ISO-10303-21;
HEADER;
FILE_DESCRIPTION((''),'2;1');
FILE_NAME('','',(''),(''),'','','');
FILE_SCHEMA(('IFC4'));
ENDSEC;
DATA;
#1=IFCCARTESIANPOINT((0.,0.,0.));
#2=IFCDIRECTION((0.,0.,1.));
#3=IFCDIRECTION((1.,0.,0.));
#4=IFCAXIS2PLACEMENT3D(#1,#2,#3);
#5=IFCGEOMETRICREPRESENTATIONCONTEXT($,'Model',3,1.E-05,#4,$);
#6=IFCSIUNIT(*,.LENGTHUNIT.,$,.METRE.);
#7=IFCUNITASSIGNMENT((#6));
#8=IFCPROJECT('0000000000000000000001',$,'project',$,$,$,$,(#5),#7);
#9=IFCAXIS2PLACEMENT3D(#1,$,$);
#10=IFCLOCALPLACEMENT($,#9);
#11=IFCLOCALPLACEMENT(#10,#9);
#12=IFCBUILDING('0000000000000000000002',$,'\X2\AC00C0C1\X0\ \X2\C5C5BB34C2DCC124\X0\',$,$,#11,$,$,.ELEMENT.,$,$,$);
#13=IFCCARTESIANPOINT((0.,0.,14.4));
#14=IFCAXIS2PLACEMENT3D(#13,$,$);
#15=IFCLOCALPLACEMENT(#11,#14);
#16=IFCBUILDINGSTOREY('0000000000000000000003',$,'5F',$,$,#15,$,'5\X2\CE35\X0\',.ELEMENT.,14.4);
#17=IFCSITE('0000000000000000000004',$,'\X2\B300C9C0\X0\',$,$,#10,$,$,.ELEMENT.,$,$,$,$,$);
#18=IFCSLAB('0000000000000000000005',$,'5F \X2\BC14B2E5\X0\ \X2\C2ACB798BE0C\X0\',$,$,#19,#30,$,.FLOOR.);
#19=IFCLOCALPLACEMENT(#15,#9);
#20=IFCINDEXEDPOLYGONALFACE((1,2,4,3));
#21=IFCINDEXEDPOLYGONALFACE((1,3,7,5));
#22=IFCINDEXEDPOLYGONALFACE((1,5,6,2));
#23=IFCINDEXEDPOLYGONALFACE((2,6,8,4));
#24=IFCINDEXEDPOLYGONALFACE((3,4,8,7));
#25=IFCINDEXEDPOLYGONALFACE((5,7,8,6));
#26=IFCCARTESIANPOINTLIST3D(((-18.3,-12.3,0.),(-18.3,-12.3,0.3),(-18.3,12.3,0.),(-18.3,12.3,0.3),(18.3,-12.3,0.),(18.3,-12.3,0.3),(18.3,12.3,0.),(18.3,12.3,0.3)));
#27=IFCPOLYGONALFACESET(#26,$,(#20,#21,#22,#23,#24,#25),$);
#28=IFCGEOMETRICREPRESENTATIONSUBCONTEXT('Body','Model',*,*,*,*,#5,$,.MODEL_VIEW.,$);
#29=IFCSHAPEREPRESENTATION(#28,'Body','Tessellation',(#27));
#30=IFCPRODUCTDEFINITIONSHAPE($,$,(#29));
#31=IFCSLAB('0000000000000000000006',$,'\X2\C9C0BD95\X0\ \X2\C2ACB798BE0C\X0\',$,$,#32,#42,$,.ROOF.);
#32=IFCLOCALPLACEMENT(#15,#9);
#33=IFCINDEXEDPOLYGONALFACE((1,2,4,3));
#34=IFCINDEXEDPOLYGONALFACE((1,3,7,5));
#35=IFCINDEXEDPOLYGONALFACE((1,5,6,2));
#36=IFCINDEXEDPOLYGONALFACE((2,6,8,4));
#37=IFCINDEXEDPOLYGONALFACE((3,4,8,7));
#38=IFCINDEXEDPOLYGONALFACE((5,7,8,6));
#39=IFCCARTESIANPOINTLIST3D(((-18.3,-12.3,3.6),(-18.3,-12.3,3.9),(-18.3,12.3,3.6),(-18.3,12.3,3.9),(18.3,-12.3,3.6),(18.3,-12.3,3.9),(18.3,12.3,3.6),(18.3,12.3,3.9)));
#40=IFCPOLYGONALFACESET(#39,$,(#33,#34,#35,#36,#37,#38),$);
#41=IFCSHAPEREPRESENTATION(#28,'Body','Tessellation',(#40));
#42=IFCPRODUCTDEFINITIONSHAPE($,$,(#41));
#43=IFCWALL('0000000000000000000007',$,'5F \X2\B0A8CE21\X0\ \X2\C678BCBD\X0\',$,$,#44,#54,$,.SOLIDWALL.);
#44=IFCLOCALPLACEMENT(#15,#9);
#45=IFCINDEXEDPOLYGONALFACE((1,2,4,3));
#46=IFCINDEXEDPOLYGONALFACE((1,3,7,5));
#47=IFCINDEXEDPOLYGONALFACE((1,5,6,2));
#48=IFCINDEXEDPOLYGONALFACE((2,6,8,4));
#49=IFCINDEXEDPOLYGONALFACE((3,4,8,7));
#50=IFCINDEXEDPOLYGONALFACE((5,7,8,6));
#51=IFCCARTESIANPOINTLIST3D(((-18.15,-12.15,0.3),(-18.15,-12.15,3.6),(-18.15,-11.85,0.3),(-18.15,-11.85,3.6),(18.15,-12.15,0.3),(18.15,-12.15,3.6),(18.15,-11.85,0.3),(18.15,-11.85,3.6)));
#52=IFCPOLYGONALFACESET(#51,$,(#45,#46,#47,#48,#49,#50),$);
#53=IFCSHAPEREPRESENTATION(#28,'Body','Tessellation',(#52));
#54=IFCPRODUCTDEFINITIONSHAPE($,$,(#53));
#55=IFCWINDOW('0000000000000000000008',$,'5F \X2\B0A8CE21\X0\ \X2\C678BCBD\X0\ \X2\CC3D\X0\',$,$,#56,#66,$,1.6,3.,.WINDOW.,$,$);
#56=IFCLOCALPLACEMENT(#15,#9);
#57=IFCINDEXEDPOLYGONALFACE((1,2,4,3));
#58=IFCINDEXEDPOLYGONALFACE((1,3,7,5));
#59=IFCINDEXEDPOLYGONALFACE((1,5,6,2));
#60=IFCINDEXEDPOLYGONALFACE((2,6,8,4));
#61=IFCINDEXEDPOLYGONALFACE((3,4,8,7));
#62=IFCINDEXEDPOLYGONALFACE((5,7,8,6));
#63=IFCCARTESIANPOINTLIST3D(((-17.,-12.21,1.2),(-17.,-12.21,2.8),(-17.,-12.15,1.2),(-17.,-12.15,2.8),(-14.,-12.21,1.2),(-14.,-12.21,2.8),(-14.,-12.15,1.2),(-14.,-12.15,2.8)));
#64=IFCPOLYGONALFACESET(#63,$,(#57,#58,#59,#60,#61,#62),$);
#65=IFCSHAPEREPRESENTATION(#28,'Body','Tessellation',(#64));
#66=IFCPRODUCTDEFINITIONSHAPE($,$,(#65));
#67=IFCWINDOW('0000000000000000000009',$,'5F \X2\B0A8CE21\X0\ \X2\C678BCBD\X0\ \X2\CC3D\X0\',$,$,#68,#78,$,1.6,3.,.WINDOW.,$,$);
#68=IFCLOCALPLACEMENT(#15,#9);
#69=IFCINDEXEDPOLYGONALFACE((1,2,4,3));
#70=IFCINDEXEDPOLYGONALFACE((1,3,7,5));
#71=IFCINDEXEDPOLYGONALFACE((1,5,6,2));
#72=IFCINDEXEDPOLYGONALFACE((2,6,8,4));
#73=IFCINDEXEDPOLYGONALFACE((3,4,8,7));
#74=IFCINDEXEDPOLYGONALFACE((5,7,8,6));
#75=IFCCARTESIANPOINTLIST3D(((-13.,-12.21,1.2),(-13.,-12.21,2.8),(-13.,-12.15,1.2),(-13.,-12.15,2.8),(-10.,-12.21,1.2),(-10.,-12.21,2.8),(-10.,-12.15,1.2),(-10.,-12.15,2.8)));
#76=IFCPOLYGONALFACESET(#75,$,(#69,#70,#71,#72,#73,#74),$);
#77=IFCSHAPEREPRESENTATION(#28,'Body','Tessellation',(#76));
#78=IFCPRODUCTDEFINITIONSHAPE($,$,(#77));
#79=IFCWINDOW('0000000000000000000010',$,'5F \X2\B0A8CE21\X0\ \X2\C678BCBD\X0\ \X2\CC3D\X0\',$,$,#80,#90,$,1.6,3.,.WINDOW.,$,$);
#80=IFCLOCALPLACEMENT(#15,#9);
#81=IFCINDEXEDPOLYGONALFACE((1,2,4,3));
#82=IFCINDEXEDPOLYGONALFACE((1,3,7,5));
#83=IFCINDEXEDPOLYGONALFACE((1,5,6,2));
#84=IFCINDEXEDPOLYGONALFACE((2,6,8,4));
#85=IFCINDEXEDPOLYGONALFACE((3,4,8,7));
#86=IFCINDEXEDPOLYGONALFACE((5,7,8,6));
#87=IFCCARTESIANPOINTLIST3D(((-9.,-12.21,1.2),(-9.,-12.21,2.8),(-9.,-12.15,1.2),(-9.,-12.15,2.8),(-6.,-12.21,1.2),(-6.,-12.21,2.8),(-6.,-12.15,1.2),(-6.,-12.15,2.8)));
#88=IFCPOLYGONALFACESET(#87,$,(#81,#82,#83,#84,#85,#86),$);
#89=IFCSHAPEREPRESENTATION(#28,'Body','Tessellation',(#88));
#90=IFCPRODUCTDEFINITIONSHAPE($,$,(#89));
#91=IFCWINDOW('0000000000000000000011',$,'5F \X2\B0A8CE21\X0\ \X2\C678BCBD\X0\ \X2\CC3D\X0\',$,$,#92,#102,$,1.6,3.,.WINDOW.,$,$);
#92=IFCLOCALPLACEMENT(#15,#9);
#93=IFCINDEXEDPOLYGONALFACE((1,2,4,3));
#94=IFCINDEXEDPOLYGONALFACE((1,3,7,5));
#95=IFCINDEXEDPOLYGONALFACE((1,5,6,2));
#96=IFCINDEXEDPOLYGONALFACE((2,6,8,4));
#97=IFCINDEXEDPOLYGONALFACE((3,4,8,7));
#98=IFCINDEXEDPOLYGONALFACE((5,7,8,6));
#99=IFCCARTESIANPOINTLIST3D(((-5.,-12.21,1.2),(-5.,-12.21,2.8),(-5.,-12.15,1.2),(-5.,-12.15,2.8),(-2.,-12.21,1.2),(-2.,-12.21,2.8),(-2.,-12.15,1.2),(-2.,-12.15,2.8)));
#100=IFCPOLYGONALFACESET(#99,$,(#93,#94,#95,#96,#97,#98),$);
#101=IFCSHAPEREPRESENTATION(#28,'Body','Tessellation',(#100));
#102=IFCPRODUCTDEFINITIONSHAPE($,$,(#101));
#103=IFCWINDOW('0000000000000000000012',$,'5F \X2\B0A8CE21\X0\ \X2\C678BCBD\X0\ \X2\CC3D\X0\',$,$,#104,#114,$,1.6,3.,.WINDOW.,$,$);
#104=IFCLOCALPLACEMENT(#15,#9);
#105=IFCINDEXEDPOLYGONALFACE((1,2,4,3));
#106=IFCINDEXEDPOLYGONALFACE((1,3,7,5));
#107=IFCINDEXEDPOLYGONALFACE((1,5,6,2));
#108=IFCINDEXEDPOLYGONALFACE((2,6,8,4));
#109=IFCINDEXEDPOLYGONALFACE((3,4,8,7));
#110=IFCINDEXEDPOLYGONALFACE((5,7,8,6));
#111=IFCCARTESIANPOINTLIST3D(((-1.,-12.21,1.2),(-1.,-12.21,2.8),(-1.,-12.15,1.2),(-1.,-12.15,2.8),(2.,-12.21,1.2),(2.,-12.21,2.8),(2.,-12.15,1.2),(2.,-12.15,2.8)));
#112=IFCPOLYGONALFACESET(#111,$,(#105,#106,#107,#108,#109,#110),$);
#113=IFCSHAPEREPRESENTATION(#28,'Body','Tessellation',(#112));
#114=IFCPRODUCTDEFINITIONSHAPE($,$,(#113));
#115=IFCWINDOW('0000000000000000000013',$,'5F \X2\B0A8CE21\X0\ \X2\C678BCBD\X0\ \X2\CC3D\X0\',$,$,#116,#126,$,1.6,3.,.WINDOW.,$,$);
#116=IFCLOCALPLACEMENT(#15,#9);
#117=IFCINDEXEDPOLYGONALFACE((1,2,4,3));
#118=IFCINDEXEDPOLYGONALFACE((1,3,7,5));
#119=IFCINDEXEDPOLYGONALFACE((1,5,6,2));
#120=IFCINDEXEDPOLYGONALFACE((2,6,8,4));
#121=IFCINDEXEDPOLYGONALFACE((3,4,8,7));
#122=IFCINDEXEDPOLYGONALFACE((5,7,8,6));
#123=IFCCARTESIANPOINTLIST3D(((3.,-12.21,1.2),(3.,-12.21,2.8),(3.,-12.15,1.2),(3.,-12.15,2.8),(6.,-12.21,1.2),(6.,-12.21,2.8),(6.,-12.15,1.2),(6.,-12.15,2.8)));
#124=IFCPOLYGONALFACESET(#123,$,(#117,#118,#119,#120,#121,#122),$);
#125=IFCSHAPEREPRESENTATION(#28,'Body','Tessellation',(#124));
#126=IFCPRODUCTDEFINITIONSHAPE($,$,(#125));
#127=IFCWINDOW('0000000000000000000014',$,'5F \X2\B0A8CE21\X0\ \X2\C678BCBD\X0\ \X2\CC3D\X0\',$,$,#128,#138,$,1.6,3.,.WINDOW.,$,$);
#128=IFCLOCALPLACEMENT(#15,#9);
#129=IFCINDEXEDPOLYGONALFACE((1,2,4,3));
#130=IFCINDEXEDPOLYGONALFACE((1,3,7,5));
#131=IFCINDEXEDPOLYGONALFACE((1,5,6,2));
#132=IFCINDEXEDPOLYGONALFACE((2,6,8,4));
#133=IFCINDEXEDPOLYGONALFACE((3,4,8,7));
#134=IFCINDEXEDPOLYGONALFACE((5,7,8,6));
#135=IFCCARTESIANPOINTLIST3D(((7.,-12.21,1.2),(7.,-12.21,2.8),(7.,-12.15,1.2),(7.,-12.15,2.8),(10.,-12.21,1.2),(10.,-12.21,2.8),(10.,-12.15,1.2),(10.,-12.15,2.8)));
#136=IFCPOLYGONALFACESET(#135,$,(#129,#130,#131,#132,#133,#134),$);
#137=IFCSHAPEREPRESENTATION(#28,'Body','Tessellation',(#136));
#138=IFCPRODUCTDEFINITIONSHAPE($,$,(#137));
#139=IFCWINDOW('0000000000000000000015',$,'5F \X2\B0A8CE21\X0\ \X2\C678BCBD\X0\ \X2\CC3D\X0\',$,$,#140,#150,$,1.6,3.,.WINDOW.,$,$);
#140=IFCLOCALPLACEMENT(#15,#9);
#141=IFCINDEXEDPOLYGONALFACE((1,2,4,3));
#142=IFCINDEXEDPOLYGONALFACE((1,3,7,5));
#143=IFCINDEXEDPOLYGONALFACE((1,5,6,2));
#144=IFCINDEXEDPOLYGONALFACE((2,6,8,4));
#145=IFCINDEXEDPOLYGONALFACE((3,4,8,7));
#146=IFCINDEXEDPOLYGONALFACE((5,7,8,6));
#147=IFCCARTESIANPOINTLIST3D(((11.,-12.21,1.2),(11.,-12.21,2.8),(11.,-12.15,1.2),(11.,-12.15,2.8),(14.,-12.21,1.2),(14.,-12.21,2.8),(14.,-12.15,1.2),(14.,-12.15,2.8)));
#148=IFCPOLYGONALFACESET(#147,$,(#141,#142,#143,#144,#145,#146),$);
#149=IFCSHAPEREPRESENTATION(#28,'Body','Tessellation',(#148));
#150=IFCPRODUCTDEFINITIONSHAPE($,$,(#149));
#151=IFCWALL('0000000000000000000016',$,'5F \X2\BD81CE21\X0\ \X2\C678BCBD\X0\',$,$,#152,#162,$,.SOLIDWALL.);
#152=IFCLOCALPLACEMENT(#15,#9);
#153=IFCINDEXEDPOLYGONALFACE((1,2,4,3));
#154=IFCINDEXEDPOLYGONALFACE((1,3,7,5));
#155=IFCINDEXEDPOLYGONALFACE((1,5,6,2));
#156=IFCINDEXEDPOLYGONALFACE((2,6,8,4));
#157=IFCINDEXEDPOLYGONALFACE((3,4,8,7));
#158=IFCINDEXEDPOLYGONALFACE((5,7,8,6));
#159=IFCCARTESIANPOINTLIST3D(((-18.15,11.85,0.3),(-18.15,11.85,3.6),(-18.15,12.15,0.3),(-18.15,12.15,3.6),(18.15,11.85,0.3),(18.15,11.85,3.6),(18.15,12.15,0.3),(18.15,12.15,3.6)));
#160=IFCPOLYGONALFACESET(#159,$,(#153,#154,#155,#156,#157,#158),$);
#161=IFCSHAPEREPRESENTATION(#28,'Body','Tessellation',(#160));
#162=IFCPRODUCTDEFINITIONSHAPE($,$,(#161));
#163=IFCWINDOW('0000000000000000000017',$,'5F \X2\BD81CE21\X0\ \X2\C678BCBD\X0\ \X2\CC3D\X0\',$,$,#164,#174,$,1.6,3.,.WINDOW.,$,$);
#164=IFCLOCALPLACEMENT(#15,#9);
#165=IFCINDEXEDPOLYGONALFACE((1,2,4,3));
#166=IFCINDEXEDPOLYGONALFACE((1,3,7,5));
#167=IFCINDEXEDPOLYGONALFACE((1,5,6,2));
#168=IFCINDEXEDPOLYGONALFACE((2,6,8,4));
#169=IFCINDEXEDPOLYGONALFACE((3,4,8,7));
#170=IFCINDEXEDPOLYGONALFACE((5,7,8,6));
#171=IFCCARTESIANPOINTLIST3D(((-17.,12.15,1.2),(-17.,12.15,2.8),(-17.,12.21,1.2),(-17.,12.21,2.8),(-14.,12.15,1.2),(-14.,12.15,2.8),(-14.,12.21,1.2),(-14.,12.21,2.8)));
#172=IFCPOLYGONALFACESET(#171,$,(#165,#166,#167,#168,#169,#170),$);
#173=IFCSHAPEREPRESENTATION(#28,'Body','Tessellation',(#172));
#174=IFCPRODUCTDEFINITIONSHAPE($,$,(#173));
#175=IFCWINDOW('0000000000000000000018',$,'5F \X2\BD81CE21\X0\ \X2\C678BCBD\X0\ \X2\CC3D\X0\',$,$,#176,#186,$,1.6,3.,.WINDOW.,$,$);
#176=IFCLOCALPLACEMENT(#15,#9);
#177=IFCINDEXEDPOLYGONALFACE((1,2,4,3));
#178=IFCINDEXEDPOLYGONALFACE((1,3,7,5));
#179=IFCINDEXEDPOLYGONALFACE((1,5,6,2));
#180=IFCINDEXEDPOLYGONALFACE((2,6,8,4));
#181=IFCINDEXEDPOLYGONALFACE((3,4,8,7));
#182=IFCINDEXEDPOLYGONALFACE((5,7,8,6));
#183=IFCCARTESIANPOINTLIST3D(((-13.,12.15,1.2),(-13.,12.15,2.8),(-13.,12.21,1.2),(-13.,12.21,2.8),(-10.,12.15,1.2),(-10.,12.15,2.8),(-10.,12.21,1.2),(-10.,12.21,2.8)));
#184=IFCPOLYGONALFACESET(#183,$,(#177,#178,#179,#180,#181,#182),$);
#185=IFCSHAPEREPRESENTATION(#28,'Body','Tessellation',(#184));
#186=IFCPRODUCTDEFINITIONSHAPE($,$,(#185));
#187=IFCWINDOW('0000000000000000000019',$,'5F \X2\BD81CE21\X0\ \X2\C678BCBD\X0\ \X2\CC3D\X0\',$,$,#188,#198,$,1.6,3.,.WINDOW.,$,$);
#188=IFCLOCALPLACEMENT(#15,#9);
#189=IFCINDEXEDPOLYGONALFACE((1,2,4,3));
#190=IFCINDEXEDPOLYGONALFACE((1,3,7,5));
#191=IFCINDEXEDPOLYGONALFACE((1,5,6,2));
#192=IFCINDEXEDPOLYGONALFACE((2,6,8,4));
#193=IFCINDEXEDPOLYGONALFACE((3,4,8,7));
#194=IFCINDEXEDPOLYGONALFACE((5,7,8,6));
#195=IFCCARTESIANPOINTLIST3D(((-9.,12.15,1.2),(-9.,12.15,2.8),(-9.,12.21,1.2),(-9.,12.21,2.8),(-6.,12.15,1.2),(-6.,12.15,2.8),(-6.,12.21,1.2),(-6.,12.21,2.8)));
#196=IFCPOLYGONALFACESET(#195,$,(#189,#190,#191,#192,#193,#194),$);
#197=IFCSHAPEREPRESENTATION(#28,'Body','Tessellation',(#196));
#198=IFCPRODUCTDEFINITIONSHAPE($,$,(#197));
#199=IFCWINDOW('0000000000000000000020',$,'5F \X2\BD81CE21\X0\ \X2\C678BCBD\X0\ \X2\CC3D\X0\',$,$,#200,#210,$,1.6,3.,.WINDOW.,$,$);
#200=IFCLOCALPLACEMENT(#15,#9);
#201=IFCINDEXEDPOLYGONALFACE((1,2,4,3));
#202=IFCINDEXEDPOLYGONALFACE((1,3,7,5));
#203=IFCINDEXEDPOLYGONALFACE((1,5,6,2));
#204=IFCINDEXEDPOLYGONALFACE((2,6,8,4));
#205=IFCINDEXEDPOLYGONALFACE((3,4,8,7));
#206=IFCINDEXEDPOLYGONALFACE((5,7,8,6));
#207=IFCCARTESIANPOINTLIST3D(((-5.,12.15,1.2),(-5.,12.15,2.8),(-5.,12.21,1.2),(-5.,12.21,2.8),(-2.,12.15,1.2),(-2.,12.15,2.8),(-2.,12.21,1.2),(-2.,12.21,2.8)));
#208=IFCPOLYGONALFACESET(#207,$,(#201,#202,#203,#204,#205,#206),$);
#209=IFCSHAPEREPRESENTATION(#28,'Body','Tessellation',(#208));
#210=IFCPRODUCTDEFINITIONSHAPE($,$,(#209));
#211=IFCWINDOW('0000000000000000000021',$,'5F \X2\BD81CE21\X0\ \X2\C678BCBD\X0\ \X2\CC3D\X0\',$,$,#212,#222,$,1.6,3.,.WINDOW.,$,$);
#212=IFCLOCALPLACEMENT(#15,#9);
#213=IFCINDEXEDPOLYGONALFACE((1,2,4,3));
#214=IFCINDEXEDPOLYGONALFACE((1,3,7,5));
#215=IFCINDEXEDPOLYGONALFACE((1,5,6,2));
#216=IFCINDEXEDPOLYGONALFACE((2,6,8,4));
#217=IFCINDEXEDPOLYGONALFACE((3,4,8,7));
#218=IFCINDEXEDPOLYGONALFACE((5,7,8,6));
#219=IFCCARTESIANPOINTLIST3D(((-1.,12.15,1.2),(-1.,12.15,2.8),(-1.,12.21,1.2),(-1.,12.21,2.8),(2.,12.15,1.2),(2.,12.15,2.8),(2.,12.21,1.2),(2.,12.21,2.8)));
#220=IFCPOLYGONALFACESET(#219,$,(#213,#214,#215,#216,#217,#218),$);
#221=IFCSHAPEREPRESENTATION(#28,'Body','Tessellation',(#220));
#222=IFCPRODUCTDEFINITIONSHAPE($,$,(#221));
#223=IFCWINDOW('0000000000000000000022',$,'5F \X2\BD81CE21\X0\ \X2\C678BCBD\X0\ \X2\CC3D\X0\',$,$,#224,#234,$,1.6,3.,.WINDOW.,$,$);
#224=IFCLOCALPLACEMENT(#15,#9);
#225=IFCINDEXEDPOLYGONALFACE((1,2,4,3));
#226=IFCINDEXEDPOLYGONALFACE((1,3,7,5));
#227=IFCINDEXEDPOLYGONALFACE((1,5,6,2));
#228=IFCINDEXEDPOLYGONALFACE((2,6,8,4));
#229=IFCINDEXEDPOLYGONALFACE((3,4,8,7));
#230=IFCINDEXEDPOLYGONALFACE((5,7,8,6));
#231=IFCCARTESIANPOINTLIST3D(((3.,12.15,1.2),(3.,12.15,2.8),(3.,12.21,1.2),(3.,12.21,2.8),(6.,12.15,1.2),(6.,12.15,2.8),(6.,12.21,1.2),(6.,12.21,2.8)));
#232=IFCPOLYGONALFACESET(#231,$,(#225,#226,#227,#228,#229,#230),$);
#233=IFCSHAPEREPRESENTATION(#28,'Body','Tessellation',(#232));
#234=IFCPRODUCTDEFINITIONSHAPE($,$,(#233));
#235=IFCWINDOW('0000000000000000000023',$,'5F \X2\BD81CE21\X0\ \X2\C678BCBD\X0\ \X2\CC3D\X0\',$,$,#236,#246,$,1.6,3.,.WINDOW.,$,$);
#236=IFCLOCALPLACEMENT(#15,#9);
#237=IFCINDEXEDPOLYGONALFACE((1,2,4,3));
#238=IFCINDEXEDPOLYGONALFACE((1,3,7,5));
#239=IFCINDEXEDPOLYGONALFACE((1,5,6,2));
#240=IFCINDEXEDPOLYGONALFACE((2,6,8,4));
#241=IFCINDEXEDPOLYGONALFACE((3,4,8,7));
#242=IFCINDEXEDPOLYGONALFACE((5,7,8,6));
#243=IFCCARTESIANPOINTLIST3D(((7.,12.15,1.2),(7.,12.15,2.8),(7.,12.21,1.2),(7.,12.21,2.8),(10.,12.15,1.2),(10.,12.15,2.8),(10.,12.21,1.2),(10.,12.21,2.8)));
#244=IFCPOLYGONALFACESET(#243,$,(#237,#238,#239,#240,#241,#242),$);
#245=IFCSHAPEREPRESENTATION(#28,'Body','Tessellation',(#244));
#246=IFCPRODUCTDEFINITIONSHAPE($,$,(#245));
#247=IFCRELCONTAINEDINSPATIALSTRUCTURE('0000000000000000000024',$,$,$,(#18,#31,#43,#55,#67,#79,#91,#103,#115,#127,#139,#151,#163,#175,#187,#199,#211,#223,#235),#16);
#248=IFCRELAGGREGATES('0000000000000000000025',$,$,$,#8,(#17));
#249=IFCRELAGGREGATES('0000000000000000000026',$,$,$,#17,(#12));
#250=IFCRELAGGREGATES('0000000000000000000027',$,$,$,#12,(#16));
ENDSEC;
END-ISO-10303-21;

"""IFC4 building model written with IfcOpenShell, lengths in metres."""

from ifc_helpers import new_model, si_unit, frame, origin, origin_with_axes, origin_2d, place, context, subcontext, project, spatial, rectangle, extrude, element, save


model = new_model("IFC4")

# Units and contexts
model_context = context("Model", 3, precision=1e-05, world=origin_with_axes())
body_context = subcontext(model_context, "Body", "Model", "MODEL_VIEW")
ifc_project = project(units=[si_unit("LENGTHUNIT", "METRE")], contexts=[model_context])

# Site, building, storey
site_placement = place(None, origin())
site = spatial("IfcSite", under=ifc_project, at=site_placement, Name="대지", CompositionType="ELEMENT")
building_placement = place(site_placement, origin())
building = spatial("IfcBuilding", under=site, at=building_placement, Name="가상 업무시설", CompositionType="ELEMENT")
storey_placement = place(building_placement, frame((0.0, 0.0, 14.4)))
storey = spatial("IfcBuildingStorey", under=building, at=storey_placement, Name="5F", LongName="5층", CompositionType="ELEMENT", Elevation=14.4)

# Slabs
slab_1_placement = place(storey_placement, origin())
element("IfcSlab", 1, at=slab_1_placement, inside=storey, Name="5F 바닥 슬래브", PredefinedType="FLOOR", context=body_context, shape_type="SweptSolid", body=[
    extrude(rectangle(XDim=36.6, YDim=24.6, at=origin_2d()), origin_with_axes(), (0.0, 0.0, 1.0), 0.3),
])
slab_2_placement = place(storey_placement, frame((0.0, 0.0, 3.6)))
element("IfcSlab", 2, at=slab_2_placement, inside=storey, Name="지붕 슬래브", PredefinedType="ROOF", context=body_context, shape_type="SweptSolid", body=[
    extrude(rectangle(XDim=36.6, YDim=24.6, at=origin_2d()), origin_with_axes(), (0.0, 0.0, 1.0), 0.3),
])

# Wall
wall_1_placement = place(storey_placement, frame((0.0, -12.0, 0.3)))
element("IfcWall", 3, at=wall_1_placement, inside=storey, Name="5F 남측 외벽", PredefinedType="SOLIDWALL", context=body_context, shape_type="SweptSolid", body=[
    extrude(rectangle(XDim=36.3, YDim=0.3, at=origin_2d()), origin_with_axes(), (0.0, 0.0, 1.0), 3.3),
])

# Windows
for number, where, name in (
    (4, (-15.5, -12.18, 1.2), "5F 남측 외벽 창"),
    (5, (-11.5, -12.18, 1.2), "5F 남측 외벽 창"),
    (6, (-7.5, -12.18, 1.2), "5F 남측 외벽 창"),
    (7, (-3.5, -12.18, 1.2), "5F 남측 외벽 창"),
    (8, (0.5, -12.18, 1.2), "5F 남측 외벽 창"),
    (9, (4.5, -12.18, 1.2), "5F 남측 외벽 창"),
    (10, (8.5, -12.18, 1.2), "5F 남측 외벽 창"),
    (11, (12.5, -12.18, 1.2), "5F 남측 외벽 창"),
):
    element("IfcWindow", number, at=place(storey_placement, frame(where)), inside=storey, Name=name, OverallHeight=1.6, OverallWidth=3.0, PredefinedType="WINDOW", context=body_context, shape_type="SweptSolid", body=[
        extrude(rectangle(XDim=3.0, YDim=0.06, at=origin_2d()), origin_with_axes(), (0.0, 0.0, 1.0), 1.6),
    ])

# Wall
wall_2_placement = place(storey_placement, frame((0.0, 12.0, 0.3)))
element("IfcWall", 12, at=wall_2_placement, inside=storey, Name="5F 북측 외벽", PredefinedType="SOLIDWALL", context=body_context, shape_type="SweptSolid", body=[
    extrude(rectangle(XDim=36.3, YDim=0.3, at=origin_2d()), origin_with_axes(), (0.0, 0.0, 1.0), 3.3),
])

# Windows
for number, where, name in (
    (13, (-15.5, 12.18, 1.2), "5F 북측 외벽 창"),
    (14, (-11.5, 12.18, 1.2), "5F 북측 외벽 창"),
    (15, (-7.5, 12.18, 1.2), "5F 북측 외벽 창"),
    (16, (-3.5, 12.18, 1.2), "5F 북측 외벽 창"),
    (17, (0.5, 12.18, 1.2), "5F 북측 외벽 창"),
    (18, (4.5, 12.18, 1.2), "5F 북측 외벽 창"),
    (19, (8.5, 12.18, 1.2), "5F 북측 외벽 창"),
):
    element("IfcWindow", number, at=place(storey_placement, frame(where)), inside=storey, Name=name, OverallHeight=1.6, OverallWidth=3.0, PredefinedType="WINDOW", context=body_context, shape_type="SweptSolid", body=[
        extrude(rectangle(XDim=3.0, YDim=0.06, at=origin_2d()), origin_with_axes(), (0.0, 0.0, 1.0), 1.6),
    ])

save(model, "model.ifc")
